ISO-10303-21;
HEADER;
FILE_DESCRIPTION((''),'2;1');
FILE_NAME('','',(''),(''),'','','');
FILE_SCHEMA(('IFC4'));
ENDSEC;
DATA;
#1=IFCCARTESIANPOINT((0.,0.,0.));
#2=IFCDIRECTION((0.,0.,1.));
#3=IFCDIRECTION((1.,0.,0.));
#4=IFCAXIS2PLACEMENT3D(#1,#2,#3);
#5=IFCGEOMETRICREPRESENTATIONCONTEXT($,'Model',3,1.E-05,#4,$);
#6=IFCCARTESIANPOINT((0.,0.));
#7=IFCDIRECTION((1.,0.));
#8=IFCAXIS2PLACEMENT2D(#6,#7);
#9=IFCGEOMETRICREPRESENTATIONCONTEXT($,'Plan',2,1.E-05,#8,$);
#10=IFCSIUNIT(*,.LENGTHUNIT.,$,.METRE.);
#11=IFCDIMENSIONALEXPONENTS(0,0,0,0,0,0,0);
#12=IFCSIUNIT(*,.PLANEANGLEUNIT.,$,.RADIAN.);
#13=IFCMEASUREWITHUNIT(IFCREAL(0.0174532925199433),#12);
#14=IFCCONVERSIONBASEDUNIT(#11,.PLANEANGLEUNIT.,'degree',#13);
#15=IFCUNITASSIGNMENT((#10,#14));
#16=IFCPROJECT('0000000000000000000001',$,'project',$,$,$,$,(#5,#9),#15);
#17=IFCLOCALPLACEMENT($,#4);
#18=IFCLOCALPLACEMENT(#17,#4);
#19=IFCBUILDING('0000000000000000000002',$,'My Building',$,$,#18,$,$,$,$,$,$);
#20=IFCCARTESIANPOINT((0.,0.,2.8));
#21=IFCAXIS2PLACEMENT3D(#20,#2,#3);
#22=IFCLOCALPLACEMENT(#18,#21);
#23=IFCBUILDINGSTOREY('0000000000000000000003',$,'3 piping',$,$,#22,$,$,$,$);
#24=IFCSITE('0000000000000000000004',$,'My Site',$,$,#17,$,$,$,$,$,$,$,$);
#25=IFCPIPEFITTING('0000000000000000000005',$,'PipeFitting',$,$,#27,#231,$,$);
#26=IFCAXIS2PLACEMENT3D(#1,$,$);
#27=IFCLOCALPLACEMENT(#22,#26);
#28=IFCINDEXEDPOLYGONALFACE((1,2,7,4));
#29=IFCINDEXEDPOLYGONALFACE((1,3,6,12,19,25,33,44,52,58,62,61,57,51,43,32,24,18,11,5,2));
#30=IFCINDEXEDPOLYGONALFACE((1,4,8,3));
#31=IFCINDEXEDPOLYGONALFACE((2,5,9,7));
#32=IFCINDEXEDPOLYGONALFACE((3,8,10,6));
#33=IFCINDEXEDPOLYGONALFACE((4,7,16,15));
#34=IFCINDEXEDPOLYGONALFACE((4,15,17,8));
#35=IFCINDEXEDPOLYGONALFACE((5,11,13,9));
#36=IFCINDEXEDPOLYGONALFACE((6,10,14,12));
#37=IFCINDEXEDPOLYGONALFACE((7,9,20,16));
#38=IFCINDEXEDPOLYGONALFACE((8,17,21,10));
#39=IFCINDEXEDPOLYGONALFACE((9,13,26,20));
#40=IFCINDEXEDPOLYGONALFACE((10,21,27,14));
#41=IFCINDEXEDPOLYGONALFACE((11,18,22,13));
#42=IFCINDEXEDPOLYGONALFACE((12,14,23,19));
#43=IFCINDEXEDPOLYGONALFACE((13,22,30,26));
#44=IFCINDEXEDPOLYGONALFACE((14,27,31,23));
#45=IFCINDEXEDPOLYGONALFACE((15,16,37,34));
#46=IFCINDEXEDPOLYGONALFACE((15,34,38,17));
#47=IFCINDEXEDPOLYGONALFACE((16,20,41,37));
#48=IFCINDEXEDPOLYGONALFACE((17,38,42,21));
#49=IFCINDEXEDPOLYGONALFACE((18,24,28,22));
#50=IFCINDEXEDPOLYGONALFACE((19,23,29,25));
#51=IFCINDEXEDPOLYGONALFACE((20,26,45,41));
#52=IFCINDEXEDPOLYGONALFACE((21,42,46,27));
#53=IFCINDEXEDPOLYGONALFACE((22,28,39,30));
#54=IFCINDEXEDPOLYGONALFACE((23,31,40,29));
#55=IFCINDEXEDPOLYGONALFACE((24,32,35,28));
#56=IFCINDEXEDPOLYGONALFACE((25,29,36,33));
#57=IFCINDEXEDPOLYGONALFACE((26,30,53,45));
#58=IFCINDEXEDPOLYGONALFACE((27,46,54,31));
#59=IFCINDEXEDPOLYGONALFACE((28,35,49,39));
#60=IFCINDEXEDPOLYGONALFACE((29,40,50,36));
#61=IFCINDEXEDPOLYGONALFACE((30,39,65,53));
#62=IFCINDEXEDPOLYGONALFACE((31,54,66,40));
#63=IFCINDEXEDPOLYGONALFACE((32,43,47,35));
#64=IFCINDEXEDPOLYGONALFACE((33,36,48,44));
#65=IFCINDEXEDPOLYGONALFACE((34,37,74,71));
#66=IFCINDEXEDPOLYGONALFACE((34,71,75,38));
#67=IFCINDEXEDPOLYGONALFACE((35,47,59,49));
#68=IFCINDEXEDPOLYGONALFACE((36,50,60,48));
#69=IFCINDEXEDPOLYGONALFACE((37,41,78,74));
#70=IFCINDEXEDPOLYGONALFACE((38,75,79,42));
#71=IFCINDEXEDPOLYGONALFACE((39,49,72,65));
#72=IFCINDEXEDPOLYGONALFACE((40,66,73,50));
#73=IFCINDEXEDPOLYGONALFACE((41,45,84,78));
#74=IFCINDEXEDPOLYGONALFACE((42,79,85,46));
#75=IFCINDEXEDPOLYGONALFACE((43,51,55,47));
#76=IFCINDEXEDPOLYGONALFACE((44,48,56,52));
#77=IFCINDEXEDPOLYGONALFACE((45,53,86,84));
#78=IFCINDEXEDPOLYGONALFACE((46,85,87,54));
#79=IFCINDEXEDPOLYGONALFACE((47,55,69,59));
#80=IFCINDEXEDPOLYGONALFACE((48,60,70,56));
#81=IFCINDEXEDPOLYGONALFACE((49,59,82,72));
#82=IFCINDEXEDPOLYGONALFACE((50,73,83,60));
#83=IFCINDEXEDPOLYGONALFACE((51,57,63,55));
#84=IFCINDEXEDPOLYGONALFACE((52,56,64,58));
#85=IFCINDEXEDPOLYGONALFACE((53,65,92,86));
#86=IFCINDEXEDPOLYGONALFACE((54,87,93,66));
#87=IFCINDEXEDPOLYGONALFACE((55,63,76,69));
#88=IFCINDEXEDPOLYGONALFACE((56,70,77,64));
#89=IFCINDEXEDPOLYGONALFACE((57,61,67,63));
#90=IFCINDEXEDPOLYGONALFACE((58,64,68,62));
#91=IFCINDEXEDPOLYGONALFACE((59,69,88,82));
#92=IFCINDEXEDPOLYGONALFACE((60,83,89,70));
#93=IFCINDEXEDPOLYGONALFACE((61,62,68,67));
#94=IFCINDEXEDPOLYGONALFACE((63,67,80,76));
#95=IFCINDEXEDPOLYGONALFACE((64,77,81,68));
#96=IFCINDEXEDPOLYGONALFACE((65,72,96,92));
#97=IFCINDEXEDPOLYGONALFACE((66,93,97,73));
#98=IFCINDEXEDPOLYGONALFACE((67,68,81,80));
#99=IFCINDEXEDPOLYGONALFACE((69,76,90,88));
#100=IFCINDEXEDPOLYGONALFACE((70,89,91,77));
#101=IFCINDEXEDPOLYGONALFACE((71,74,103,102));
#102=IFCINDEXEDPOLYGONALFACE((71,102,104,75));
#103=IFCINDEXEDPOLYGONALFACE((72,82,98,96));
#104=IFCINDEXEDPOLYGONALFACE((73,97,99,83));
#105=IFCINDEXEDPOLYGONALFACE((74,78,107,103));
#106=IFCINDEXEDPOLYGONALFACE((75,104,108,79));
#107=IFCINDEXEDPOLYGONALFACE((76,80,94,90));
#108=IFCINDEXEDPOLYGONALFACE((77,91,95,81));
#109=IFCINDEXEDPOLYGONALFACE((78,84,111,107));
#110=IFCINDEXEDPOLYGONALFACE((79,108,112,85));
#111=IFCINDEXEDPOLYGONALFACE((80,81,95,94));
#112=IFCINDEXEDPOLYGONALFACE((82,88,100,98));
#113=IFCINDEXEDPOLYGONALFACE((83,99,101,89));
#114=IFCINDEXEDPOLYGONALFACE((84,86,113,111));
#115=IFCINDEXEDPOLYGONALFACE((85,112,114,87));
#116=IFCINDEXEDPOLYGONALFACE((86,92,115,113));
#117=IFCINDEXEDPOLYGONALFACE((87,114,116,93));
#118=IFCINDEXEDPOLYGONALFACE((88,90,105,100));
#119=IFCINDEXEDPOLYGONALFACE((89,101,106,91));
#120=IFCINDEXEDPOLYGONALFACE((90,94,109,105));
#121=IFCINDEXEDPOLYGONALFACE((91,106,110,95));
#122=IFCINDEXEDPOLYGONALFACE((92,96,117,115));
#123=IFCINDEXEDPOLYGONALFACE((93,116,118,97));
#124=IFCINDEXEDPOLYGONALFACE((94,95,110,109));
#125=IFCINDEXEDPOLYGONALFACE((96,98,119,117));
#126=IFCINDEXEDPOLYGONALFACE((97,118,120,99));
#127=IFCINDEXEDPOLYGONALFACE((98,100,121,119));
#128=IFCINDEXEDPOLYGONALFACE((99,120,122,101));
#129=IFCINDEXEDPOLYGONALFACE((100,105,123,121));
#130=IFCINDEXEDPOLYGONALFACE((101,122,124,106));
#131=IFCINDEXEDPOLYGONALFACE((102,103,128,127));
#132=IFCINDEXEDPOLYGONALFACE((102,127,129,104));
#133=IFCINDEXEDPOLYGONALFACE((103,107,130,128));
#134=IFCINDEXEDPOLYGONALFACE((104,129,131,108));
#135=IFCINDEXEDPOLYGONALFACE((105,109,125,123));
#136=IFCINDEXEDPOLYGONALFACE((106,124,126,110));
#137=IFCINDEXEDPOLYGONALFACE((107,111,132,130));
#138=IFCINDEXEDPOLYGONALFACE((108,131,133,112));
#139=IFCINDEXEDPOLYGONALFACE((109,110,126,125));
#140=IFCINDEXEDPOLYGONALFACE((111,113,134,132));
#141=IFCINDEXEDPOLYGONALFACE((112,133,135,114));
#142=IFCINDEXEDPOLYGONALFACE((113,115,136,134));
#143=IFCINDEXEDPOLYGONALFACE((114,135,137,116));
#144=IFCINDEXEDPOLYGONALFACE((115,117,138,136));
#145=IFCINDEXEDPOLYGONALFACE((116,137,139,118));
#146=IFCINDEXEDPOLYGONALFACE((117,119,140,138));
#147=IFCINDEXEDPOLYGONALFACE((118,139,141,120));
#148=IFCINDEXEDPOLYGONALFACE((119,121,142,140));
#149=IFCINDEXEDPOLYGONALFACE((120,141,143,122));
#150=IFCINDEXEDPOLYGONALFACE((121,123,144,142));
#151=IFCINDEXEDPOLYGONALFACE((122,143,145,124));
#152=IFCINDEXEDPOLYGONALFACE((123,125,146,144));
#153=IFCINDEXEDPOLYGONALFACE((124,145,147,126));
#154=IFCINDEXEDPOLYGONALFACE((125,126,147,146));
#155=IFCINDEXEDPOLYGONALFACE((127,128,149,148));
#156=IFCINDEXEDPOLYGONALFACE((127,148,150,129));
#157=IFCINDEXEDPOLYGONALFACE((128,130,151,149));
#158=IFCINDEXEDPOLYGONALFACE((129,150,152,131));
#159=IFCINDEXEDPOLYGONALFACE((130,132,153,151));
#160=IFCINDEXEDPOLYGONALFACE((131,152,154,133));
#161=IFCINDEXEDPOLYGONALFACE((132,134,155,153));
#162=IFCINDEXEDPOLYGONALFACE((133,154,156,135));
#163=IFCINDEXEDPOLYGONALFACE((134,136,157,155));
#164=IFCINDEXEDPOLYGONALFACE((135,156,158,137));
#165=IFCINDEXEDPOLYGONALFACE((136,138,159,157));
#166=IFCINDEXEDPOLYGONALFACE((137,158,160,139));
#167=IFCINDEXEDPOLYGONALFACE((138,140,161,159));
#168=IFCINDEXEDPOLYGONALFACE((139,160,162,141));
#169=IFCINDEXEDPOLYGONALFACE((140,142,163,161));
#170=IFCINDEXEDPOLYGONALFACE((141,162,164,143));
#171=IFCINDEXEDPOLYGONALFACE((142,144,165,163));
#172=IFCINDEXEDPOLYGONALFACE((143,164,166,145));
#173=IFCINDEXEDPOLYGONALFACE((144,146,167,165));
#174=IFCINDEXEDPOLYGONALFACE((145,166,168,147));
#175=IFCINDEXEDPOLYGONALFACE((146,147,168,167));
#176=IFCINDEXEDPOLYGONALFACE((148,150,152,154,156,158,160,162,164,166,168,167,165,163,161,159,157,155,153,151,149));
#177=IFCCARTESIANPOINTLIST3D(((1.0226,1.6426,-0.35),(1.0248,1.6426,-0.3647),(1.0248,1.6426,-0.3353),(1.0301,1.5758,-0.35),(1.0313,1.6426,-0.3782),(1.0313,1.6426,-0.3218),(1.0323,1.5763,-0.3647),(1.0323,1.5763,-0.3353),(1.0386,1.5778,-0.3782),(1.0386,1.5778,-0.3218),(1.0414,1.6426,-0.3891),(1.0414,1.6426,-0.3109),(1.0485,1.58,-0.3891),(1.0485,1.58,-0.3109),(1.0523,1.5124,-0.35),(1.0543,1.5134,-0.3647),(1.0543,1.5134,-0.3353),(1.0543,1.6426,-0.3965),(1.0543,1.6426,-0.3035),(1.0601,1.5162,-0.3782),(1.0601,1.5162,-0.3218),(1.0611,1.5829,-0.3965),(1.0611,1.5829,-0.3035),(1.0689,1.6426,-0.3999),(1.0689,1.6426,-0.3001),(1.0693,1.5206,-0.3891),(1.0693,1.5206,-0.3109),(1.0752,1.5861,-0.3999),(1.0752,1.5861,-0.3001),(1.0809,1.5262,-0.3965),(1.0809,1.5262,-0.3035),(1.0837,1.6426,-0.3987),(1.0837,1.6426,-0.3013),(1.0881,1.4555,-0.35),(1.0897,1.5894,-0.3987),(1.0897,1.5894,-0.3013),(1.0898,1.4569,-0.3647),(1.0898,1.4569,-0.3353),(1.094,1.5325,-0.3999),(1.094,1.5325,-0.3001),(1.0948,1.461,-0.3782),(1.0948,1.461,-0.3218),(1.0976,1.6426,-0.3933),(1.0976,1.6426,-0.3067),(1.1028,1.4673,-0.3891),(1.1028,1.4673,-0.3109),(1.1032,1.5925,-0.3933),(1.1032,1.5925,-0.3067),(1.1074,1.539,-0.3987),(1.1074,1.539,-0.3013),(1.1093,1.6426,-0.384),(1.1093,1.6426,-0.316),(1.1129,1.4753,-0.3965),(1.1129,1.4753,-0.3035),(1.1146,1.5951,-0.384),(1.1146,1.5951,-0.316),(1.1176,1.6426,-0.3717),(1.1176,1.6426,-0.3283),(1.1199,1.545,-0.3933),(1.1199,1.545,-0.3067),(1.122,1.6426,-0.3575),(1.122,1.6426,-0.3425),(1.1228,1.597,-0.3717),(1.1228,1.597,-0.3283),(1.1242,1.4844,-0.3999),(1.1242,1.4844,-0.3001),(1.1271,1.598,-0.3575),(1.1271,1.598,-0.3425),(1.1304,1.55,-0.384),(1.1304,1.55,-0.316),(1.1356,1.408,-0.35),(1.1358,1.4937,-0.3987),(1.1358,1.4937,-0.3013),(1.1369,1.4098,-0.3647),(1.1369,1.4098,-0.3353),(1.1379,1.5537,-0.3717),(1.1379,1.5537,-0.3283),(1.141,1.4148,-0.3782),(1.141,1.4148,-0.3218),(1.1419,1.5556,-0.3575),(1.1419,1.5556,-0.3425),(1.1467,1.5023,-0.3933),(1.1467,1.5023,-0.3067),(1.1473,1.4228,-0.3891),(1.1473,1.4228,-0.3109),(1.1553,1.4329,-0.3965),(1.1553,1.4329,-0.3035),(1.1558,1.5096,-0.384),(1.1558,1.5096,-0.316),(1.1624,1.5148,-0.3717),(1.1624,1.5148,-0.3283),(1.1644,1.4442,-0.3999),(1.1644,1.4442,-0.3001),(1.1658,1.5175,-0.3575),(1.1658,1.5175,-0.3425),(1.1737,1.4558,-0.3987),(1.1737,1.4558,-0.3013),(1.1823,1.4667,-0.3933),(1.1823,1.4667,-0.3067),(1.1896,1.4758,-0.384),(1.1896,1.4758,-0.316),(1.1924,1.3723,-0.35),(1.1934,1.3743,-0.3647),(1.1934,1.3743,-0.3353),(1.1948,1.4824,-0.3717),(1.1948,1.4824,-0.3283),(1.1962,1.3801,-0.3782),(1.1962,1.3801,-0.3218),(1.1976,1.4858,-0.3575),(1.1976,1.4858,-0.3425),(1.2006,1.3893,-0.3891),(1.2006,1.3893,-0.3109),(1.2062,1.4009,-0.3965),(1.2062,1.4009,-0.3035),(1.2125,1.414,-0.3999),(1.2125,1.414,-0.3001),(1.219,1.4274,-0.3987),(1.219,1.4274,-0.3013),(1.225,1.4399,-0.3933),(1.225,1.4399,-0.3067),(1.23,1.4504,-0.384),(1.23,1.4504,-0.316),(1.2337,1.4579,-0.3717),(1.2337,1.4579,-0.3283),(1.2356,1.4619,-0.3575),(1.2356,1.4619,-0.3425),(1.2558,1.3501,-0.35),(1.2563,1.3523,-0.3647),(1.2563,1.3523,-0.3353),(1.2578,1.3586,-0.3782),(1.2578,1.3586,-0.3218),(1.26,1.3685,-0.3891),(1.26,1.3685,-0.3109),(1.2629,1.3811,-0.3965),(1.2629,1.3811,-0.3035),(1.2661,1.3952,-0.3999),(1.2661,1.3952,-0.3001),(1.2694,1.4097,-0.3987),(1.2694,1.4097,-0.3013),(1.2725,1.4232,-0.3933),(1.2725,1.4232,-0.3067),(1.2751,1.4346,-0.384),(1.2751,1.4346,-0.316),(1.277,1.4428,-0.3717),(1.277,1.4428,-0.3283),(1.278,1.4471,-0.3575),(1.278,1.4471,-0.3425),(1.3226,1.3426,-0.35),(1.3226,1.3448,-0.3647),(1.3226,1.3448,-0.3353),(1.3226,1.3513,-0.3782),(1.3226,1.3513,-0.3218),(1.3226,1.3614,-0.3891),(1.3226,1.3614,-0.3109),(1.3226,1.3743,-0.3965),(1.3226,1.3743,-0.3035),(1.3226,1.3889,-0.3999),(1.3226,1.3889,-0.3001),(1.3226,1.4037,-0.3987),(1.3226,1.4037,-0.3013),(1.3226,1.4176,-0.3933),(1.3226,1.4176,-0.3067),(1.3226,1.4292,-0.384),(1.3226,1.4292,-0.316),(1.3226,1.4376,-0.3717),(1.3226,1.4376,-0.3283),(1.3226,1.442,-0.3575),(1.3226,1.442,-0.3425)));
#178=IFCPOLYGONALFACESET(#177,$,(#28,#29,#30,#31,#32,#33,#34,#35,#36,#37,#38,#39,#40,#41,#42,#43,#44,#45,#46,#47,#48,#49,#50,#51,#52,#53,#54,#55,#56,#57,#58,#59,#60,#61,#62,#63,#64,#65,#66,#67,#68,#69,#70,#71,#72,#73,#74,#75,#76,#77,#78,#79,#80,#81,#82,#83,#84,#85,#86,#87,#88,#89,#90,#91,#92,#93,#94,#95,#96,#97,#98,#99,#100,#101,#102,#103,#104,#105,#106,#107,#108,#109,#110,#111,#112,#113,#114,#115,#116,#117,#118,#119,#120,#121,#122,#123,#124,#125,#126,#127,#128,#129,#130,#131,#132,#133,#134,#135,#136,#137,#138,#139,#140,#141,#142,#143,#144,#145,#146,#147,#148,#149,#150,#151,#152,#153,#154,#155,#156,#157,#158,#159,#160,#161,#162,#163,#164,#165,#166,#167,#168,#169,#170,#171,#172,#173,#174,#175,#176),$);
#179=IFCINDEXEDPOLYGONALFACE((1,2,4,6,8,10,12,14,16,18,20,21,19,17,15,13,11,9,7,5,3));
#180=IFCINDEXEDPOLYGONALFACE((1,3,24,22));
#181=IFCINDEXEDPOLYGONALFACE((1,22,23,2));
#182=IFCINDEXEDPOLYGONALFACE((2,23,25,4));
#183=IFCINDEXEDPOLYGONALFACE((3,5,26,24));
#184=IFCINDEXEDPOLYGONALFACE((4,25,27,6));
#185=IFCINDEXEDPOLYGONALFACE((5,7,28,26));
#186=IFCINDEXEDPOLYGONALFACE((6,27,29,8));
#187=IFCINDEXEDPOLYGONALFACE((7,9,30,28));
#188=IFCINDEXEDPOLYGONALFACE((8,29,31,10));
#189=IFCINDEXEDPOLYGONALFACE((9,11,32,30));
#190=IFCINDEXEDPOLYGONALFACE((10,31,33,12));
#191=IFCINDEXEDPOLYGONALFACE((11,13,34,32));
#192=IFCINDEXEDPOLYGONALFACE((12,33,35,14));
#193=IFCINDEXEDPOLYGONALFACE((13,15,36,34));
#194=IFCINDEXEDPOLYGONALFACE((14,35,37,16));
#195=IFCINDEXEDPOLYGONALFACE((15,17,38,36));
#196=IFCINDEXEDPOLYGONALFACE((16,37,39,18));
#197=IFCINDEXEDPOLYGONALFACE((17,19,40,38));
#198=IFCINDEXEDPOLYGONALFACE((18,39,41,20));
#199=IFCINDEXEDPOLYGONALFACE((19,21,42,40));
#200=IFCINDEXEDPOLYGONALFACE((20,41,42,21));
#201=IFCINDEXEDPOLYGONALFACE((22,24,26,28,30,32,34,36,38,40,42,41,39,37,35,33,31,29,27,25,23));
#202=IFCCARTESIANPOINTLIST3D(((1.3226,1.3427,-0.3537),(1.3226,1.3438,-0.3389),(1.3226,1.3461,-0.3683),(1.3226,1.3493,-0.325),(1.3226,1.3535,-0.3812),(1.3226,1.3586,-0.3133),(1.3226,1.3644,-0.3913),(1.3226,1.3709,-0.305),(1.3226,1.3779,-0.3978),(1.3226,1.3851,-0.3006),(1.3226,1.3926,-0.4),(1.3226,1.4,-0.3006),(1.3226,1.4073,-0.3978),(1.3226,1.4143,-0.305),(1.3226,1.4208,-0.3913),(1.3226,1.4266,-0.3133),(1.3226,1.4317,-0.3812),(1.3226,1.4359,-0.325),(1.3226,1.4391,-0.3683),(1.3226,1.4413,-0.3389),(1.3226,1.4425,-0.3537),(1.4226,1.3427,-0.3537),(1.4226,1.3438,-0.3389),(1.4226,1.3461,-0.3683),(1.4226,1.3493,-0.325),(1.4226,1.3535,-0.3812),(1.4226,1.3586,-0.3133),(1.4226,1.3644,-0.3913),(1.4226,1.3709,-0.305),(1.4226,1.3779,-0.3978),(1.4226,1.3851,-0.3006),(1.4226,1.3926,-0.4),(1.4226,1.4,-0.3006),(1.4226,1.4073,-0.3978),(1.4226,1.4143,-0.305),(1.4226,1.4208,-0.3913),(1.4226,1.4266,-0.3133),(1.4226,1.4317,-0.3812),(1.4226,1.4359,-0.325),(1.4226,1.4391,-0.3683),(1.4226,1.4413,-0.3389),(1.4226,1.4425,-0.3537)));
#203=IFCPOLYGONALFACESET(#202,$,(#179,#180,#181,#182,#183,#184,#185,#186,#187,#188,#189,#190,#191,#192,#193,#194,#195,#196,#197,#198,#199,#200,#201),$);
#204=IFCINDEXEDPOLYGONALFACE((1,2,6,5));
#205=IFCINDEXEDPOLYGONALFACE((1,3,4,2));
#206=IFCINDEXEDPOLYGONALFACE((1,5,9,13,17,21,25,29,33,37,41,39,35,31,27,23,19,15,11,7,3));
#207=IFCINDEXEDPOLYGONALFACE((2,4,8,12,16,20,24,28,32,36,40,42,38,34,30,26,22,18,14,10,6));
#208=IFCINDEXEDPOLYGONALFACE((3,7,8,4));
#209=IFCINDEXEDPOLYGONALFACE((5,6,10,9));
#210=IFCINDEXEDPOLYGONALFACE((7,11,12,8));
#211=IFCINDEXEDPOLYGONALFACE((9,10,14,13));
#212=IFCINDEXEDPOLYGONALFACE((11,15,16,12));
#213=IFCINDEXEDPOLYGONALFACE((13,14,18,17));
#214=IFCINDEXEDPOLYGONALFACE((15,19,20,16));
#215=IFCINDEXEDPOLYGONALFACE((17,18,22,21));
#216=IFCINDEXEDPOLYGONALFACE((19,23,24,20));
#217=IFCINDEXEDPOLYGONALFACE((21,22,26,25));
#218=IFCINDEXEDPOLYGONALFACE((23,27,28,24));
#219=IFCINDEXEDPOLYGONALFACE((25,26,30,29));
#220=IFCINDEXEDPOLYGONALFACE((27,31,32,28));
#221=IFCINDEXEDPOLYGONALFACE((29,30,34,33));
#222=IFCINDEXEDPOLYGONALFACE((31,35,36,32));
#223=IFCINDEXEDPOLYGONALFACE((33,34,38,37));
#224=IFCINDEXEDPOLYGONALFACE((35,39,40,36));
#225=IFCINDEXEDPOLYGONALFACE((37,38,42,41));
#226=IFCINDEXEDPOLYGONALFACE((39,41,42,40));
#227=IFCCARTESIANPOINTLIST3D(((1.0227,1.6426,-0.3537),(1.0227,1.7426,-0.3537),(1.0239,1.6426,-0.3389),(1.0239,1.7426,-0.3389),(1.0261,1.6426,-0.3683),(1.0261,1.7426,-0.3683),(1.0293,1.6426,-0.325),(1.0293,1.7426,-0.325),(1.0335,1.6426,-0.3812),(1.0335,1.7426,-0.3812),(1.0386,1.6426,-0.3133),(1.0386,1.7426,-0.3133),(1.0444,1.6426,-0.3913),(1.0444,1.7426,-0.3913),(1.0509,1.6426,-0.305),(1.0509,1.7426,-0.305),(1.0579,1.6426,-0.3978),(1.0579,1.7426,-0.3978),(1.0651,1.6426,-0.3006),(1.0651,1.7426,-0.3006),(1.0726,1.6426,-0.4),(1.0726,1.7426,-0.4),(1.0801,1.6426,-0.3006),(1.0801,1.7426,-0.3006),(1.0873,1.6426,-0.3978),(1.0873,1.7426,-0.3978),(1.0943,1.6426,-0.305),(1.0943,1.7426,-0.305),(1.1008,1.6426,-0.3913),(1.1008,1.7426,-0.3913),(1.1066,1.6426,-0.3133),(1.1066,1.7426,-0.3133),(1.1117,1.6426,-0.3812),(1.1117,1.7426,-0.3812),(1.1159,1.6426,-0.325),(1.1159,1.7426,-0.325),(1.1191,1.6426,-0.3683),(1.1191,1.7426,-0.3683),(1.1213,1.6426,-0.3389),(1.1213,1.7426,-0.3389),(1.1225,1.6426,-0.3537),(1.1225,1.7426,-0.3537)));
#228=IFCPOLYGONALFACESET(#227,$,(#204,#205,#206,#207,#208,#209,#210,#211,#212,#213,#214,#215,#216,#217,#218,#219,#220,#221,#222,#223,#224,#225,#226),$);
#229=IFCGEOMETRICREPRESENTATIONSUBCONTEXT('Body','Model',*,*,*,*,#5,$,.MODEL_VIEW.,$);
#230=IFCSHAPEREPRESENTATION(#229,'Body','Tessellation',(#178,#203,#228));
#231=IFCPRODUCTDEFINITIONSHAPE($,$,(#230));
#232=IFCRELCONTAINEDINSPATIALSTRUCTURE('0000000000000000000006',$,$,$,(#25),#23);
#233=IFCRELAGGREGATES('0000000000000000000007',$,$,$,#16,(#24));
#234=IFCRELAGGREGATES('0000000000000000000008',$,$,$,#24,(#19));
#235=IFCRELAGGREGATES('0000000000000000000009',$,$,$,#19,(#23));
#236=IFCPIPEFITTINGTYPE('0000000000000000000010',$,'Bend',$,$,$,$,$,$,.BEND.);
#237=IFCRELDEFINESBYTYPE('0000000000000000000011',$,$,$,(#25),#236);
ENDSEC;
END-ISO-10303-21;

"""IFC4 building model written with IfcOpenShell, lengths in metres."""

from ifc_helpers import new_model, entity, si_unit, converted_unit, frame, origin_with_axes, origin_2d_with_axis, place, context, subcontext, project, spatial, circle, extrude, source, transform, mapped, type_object, type_shapes, element, save


model = new_model("IFC4")

# Units and contexts
model_context = context("Model", 3, precision=1e-05, world=origin_with_axes())
plan_context = context("Plan", 2, precision=1e-05, world=origin_2d_with_axis())
body_context = subcontext(model_context, "Body", "Model", "MODEL_VIEW")
ifc_project = project(units=[si_unit("LENGTHUNIT", "METRE"), converted_unit("PLANEANGLEUNIT", "degree", entity("IfcReal", 0.0174532925199433), si_unit("PLANEANGLEUNIT", "RADIAN"), dimensions=[0, 0, 0, 0, 0, 0, 0])], contexts=[model_context, plan_context])

# Site, building, storey
site_placement = place(None, origin_with_axes())
site = spatial("IfcSite", under=ifc_project, at=site_placement, Name="My Site")
building_placement = place(site_placement, origin_with_axes())
building = spatial("IfcBuilding", under=site, at=building_placement, Name="My Building")
storey_placement = place(building_placement, frame((0.0, 0.0, 2.8), z_axis=(0.0, 0.0, 1.0), x_axis=(1.0, 0.0, 0.0)))
storey = spatial("IfcBuildingStorey", under=building, at=storey_placement, Name="3 piping")

# Pipe fitting
pipe_fitting_type_1 = type_object("IfcPipeFittingType", Name="Bend", PredefinedType="BEND")
shared_shape = source(origin_with_axes(), body_context, "Body", "SolidModel", [
    entity("IfcSweptDiskSolid", entity("IfcIndexedPolyCurve", entity("IfcCartesianPointList3D", [[0.0, 0.0, 0.1], [0.0, -0.0732, 0.2768], [0.0, -0.25, 0.35]]), [entity("IfcArcIndex", [1, 2, 3])]), 0.05),
    extrude(circle(Radius=0.05), origin_with_axes(), (0.0, 0.0, 1.0), 0.1),
    extrude(circle(Radius=0.05), frame((0.0, -0.25, 0.35), z_axis=(0.0, -1.0, 0.0), x_axis=(1.0, 0.0, 0.0)), (0.0, 0.0, 1.0), 0.1),
])
type_shapes(pipe_fitting_type_1, [shared_shape])
for number, where, z_axis, x_axis, name in (
    (1, (1.4226, 1.3926, -0.35), (-1.0, 0.0, 0.0), (0.0, 0.0, -1.0), "PipeFitting"),
):
    element("IfcPipeFitting", number, at=place(storey_placement, frame(where, z_axis=z_axis, x_axis=x_axis)), inside=storey, type_object=pipe_fitting_type_1, Name=name, context=body_context, shape_type="MappedRepresentation", body=[
        mapped(shared_shape, transform((0.0, 0.0, 0.0), x_axis=(1.0, 0.0, 0.0), y_axis=(0.0, 1.0, 0.0), z_axis=(0.0, 0.0, 1.0), scale=1.0)),
    ])

save(model, "model.ifc")
